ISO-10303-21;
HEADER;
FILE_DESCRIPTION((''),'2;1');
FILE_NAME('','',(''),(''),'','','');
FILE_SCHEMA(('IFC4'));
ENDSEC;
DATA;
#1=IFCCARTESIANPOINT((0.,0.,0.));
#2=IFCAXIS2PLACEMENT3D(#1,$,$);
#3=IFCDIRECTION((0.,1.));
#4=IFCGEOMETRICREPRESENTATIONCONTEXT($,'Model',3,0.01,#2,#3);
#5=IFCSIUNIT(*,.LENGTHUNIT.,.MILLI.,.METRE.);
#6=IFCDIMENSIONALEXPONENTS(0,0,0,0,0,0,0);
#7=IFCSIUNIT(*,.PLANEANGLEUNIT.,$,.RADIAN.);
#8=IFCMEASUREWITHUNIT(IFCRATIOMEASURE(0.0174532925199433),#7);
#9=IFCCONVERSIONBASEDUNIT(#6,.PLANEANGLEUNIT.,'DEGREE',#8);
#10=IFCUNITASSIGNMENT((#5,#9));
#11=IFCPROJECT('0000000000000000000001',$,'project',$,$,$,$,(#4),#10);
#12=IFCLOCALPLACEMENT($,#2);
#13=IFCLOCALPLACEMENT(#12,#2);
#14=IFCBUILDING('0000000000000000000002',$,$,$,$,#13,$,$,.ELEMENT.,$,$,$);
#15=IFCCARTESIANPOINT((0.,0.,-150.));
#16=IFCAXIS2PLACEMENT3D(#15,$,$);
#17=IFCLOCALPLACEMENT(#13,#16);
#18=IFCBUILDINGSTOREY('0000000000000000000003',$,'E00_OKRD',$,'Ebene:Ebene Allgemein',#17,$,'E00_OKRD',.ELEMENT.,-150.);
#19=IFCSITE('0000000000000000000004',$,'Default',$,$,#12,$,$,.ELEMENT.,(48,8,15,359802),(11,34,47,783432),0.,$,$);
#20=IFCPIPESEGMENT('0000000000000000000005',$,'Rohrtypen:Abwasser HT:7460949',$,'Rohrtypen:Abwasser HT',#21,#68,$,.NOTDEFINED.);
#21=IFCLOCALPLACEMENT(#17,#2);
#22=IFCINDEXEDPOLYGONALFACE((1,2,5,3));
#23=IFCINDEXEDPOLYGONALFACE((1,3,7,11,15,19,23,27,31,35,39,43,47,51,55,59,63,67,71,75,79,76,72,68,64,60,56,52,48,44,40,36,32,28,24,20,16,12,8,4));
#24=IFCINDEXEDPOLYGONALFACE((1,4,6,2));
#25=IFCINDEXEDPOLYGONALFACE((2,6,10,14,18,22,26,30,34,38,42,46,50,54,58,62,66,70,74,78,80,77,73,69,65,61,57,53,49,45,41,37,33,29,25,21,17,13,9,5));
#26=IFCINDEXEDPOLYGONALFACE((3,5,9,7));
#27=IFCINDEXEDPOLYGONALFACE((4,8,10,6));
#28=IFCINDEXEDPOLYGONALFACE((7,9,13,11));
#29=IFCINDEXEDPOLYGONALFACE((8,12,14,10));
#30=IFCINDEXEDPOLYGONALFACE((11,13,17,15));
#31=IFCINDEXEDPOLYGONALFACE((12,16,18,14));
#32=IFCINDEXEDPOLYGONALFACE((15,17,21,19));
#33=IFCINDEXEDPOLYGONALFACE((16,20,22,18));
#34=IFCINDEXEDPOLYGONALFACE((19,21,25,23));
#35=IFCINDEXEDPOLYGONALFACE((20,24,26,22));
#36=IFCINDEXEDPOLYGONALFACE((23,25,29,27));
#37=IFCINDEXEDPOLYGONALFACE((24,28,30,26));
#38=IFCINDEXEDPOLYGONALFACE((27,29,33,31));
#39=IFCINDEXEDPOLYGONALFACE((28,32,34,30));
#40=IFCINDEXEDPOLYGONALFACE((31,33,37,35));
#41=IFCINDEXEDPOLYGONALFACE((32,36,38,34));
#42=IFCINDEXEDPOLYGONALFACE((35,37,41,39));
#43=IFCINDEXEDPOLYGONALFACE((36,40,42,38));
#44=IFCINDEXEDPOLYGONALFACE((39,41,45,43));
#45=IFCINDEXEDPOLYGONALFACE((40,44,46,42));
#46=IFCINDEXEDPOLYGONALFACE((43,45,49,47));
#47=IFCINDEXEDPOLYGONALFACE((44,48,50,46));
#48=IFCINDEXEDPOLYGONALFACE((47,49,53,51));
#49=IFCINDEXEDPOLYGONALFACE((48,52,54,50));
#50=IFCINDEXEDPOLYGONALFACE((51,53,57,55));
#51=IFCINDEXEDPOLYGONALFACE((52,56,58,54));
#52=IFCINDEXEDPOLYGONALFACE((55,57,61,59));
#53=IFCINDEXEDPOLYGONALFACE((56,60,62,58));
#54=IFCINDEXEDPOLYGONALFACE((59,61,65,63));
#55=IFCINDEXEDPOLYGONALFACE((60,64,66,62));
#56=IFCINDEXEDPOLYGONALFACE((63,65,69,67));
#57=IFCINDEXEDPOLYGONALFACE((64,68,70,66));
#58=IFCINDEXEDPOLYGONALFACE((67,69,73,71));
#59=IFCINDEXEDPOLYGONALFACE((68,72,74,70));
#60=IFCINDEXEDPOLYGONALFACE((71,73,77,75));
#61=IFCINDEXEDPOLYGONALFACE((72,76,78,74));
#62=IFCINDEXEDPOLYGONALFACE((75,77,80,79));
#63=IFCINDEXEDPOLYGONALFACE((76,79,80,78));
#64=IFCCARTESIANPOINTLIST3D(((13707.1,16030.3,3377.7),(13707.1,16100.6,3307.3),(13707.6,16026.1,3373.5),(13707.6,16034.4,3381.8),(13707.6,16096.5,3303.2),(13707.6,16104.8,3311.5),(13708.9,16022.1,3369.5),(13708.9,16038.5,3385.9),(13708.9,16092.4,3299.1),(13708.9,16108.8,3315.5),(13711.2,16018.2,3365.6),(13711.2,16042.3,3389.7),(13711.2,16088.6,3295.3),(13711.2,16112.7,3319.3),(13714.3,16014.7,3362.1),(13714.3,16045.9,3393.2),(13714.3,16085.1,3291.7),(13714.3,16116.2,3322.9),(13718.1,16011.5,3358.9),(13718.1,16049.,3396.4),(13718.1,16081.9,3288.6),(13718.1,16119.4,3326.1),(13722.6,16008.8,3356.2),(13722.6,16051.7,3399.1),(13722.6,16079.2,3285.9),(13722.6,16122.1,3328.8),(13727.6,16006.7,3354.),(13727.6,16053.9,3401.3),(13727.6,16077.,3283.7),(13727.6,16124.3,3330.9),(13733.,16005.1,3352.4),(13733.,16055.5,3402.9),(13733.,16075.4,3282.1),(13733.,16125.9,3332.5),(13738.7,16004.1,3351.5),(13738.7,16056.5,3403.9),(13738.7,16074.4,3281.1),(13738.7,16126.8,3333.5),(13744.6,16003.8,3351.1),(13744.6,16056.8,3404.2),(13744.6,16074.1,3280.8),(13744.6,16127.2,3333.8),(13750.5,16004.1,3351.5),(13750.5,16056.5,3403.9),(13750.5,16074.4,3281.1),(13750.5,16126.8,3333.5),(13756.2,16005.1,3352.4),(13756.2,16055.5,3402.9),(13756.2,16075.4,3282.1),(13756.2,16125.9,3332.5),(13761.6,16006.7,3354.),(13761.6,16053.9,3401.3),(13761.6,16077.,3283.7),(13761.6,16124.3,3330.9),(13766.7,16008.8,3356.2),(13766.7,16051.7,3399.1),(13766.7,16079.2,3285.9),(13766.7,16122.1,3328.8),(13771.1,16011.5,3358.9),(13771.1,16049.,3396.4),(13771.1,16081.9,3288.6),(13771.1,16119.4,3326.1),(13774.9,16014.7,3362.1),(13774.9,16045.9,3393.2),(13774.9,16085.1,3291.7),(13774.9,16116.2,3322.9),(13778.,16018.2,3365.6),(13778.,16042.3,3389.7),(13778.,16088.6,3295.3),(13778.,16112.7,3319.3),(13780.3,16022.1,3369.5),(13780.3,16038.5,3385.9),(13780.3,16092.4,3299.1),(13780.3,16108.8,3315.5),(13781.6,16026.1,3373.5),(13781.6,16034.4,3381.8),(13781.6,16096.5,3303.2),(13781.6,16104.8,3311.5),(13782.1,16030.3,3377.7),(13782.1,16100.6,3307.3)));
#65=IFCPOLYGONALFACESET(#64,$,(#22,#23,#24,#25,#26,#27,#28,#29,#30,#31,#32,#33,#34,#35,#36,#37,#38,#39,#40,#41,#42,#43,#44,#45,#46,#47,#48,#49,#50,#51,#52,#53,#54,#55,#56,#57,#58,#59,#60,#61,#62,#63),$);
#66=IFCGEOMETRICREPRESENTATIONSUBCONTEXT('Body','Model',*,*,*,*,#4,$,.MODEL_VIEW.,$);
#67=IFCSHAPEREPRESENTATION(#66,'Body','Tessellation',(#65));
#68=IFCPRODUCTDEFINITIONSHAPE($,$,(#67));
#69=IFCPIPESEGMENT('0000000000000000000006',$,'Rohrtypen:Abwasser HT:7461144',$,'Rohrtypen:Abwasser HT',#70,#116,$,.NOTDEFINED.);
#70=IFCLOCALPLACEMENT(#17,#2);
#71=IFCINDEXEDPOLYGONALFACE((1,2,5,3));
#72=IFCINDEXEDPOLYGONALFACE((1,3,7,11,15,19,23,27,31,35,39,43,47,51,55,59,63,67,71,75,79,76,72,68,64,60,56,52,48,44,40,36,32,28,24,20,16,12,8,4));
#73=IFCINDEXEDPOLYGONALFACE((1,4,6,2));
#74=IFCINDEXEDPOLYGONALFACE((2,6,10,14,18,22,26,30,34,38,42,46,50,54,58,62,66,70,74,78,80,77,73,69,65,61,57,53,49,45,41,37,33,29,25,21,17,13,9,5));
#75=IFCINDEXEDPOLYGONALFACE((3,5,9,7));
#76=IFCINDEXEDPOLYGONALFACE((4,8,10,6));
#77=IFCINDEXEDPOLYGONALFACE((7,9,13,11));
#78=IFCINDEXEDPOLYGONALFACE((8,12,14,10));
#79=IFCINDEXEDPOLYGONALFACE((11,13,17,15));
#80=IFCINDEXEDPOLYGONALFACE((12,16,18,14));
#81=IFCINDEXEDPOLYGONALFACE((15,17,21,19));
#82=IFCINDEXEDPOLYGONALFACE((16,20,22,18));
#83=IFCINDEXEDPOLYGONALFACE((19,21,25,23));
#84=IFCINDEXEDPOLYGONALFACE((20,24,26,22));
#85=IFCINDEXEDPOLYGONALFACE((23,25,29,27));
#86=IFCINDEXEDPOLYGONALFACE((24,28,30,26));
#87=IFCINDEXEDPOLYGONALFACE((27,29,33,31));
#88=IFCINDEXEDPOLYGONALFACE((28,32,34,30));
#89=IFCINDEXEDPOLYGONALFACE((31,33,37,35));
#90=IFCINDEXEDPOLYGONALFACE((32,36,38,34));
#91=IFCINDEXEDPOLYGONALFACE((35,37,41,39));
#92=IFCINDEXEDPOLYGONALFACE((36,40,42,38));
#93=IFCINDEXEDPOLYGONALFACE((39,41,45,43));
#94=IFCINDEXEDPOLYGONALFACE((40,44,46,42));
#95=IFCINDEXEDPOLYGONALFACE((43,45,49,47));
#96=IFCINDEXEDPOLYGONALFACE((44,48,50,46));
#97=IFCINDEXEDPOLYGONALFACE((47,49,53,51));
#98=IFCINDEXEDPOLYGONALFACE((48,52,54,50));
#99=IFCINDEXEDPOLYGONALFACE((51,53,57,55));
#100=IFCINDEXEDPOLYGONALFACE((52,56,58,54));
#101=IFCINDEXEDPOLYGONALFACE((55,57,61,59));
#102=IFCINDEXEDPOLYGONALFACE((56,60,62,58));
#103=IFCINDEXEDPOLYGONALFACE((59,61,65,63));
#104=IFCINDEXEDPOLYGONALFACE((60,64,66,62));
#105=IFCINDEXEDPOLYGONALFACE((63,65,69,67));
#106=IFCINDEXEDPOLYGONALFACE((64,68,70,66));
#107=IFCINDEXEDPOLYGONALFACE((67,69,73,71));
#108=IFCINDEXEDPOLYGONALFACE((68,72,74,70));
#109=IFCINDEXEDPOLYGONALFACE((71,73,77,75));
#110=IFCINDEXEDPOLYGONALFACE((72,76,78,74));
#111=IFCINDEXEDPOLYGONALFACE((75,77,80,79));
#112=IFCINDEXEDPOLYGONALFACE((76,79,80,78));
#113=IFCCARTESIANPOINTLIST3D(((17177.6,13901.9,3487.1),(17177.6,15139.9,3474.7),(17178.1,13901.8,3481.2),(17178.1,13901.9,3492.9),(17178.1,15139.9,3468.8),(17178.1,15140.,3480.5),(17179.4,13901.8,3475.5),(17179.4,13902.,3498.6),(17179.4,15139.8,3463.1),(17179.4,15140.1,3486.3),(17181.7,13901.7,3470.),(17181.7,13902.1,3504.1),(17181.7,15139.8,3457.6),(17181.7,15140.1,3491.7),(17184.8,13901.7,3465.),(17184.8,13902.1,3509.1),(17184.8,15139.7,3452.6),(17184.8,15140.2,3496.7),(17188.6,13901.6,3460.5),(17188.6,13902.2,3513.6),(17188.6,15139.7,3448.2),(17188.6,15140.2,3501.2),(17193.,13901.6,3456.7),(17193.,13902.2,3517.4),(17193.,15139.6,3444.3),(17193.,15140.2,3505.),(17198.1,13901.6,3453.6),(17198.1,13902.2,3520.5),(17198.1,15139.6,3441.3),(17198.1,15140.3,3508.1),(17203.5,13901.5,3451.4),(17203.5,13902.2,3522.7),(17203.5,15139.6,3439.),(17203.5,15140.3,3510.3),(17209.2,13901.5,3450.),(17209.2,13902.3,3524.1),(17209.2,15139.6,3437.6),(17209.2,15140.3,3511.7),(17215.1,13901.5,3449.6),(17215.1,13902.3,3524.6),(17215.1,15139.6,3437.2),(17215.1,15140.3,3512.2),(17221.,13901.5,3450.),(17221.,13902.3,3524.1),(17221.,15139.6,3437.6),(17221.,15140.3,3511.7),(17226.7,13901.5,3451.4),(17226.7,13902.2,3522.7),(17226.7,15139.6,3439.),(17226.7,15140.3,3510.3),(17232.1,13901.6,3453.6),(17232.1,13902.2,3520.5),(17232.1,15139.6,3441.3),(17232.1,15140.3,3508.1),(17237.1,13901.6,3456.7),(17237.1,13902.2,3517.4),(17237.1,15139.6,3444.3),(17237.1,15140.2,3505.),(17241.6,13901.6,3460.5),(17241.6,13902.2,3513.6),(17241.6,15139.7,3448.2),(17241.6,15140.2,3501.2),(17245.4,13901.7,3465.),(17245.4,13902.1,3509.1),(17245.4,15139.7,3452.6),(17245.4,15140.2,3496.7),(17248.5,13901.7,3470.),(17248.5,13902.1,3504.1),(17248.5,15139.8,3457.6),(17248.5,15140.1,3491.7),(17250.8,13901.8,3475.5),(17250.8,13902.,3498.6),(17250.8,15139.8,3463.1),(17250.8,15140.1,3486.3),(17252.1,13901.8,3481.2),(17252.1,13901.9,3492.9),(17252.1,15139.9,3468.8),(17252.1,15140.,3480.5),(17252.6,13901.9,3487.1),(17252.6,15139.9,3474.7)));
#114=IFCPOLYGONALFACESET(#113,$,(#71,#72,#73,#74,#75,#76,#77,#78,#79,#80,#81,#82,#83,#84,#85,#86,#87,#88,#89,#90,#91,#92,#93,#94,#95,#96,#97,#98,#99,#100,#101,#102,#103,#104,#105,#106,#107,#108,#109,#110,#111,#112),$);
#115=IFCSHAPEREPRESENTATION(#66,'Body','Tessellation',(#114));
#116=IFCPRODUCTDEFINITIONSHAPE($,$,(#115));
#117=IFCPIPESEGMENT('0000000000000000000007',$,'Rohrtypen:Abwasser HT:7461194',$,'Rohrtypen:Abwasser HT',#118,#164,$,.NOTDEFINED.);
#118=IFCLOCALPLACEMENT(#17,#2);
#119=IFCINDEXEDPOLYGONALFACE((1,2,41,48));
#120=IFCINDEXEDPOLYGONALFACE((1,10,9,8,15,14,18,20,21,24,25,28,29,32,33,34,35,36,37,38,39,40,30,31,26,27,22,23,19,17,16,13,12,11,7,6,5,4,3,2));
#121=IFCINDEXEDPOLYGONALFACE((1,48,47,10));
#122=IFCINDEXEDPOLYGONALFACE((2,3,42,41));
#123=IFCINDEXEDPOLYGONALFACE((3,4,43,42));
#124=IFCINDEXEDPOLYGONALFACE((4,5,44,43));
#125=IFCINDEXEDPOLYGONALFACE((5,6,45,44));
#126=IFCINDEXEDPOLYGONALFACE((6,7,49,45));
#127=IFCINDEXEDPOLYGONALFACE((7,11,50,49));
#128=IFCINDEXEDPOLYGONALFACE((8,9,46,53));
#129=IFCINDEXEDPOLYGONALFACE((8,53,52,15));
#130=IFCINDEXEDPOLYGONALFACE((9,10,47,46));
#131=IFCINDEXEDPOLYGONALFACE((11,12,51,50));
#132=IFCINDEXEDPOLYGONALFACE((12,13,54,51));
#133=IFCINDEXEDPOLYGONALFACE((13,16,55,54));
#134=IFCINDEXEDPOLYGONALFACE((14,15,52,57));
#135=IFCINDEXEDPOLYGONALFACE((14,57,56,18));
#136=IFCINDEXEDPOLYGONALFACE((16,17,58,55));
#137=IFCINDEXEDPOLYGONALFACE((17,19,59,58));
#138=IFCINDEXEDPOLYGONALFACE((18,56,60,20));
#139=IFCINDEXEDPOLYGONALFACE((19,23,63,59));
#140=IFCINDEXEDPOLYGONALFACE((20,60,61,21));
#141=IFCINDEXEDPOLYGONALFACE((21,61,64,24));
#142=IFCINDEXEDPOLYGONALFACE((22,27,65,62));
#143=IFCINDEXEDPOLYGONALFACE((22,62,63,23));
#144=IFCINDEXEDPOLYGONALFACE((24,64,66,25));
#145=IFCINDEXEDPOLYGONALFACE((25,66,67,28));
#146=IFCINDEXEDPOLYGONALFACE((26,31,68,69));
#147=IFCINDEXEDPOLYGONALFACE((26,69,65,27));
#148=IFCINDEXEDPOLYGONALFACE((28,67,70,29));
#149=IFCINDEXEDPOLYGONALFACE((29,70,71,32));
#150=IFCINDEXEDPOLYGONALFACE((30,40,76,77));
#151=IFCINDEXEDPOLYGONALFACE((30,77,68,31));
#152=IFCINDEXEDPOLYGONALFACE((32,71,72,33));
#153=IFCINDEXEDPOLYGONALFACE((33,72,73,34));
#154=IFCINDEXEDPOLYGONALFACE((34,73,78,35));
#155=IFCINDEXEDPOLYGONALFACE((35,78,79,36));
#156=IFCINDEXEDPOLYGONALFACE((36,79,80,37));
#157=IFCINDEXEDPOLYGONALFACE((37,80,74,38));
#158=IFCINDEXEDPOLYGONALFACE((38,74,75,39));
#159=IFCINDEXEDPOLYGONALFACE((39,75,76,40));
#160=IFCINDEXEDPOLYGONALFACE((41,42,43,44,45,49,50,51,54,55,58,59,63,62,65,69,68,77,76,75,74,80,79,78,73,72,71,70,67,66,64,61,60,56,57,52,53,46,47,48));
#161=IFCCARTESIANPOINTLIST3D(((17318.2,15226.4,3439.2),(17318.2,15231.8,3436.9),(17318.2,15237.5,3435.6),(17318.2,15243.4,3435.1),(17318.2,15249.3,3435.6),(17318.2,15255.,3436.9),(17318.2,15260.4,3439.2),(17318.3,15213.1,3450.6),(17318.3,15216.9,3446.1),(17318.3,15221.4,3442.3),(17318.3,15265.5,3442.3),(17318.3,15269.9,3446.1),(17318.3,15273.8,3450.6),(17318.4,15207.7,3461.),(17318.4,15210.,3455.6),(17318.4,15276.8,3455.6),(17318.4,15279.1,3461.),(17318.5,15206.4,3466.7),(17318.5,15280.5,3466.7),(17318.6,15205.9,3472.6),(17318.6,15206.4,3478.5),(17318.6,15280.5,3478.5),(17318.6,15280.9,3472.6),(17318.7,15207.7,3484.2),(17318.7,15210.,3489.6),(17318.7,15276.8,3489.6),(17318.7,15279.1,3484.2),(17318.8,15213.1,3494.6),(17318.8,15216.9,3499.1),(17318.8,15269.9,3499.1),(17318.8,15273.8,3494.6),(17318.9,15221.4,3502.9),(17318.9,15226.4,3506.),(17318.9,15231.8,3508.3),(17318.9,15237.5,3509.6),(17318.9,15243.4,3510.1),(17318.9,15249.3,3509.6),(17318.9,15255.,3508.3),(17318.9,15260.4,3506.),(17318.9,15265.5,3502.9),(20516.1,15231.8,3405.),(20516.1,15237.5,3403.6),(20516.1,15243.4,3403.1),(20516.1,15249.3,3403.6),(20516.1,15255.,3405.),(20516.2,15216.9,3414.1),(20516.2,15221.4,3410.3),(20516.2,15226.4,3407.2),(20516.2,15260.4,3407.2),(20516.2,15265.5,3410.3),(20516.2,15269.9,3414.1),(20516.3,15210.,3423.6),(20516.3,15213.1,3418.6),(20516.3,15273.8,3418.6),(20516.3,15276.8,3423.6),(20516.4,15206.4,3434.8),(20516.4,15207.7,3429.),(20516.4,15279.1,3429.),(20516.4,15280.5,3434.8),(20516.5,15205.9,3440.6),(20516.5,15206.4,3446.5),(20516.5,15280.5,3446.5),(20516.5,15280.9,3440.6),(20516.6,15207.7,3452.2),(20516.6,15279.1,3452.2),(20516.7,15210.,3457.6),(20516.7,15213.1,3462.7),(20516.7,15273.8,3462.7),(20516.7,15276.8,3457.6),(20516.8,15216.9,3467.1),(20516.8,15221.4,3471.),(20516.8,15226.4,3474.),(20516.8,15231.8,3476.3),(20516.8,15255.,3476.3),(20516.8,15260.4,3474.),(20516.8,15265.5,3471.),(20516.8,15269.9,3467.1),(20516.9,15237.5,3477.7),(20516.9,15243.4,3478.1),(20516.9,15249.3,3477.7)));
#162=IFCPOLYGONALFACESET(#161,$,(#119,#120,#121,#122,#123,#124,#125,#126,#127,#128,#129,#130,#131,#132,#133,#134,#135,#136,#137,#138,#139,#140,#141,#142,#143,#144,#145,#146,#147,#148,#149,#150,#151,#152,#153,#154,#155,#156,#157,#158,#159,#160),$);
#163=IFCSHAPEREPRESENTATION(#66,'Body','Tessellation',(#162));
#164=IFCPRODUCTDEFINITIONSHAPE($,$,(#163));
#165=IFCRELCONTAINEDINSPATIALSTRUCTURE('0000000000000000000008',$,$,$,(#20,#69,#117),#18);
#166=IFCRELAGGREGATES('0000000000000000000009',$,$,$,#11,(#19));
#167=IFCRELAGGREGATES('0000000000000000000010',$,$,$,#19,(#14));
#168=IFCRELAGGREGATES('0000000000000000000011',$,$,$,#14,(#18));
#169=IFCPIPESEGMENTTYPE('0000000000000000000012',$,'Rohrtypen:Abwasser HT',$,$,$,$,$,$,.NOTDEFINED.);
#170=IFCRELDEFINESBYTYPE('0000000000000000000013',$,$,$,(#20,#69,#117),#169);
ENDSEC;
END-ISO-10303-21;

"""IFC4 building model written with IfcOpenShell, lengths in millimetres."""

from ifc_helpers import new_model, entity, si_unit, converted_unit, direction, frame, origin, place, context, subcontext, project, spatial, indexed_curve, outline, extrude, type_object, element, save


model = new_model("IFC4")

# Units and contexts
model_context = context("Model", 3, precision=0.01, world=origin(), true_north=direction((0.0, 1.0)))
body_context = subcontext(model_context, "Body", "Model", "MODEL_VIEW")
ifc_project = project(units=[si_unit("LENGTHUNIT", "METRE", prefix="MILLI"), converted_unit("PLANEANGLEUNIT", "DEGREE", entity("IfcRatioMeasure", 0.0174532925199433), si_unit("PLANEANGLEUNIT", "RADIAN"), dimensions=[0, 0, 0, 0, 0, 0, 0])], contexts=[model_context])

# Site, building, storey
site_placement = place(None, origin())
site = spatial("IfcSite", under=ifc_project, at=site_placement, Name="Default", CompositionType="ELEMENT", RefLatitude=(48, 8, 15, 359802), RefLongitude=(11, 34, 47, 783432), RefElevation=0.0)
building_placement = place(site_placement, origin())
building = spatial("IfcBuilding", under=site, at=building_placement, CompositionType="ELEMENT")
storey_placement = place(building_placement, frame((0.0, 0.0, -150.0)))
storey = spatial("IfcBuildingStorey", under=building, at=storey_placement, Name="E00_OKRD", ObjectType="Ebene:Ebene Allgemein", LongName="E00_OKRD", CompositionType="ELEMENT", Elevation=-150.0)

# Pipe segments
pipe_segment_type_1 = type_object("IfcPipeSegmentType", Name="Rohrtypen:Abwasser HT", PredefinedType="NOTDEFINED")
pipe_segment_1_placement = place(storey_placement, origin())
element("IfcPipeSegment", 1, at=pipe_segment_1_placement, inside=storey, type_object=pipe_segment_type_1, Name="Rohrtypen:Abwasser HT:7460949", ObjectType="Rohrtypen:Abwasser HT", PredefinedType="NOTDEFINED", context=body_context, shape_type="SweptSolid", body=[
    extrude(outline(indexed_curve([(37.5, 0.0), (37.0, 5.9), (35.7, 11.6), (33.4, 17.0), (30.3, 22.0), (26.5, 26.5), (22.0, 30.3), (17.0, 33.4), (11.6, 35.7), (5.9, 37.0), (0.0, 37.5), (-5.9, 37.0), (-11.6, 35.7), (-17.0, 33.4), (-22.0, 30.3), (-26.5, 26.5), (-30.3, 22.0), (-33.4, 17.0), (-35.7, 11.6), (-37.0, 5.9), (-37.5, 0.0), (-37.0, -5.9), (-35.7, -11.6), (-33.4, -17.0), (-30.3, -22.0), (-26.5, -26.5), (-22.0, -30.3), (-17.0, -33.4), (-11.6, -35.7), (-5.9, -37.0), (0.0, -37.5), (5.9, -37.0), (11.6, -35.7), (17.0, -33.4), (22.0, -30.3), (26.5, -26.5), (30.3, -22.0), (33.4, -17.0), (35.7, -11.6), (37.0, -5.9), (37.5, 0.0)], self_intersect=False)), frame((13744.6, 16030.3, 3377.7), z_axis=(0.0, 0.707107, -0.707107), x_axis=(1.0, 0.0, 0.0)), (0.0, 0.0, 1.0), 99.5),
])
pipe_segment_2_placement = place(storey_placement, origin())
element("IfcPipeSegment", 2, at=pipe_segment_2_placement, inside=storey, type_object=pipe_segment_type_1, Name="Rohrtypen:Abwasser HT:7461144", ObjectType="Rohrtypen:Abwasser HT", PredefinedType="NOTDEFINED", context=body_context, shape_type="SweptSolid", body=[
    extrude(outline(indexed_curve([(37.5, 0.0), (37.0, 5.9), (35.7, 11.6), (33.4, 17.0), (30.3, 22.0), (26.5, 26.5), (22.0, 30.3), (17.0, 33.4), (11.6, 35.7), (5.9, 37.0), (0.0, 37.5), (-5.9, 37.0), (-11.6, 35.7), (-17.0, 33.4), (-22.0, 30.3), (-26.5, 26.5), (-30.3, 22.0), (-33.4, 17.0), (-35.7, 11.6), (-37.0, 5.9), (-37.5, 0.0), (-37.0, -5.9), (-35.7, -11.6), (-33.4, -17.0), (-30.3, -22.0), (-26.5, -26.5), (-22.0, -30.3), (-17.0, -33.4), (-11.6, -35.7), (-5.9, -37.0), (0.0, -37.5), (5.9, -37.0), (11.6, -35.7), (17.0, -33.4), (22.0, -30.3), (26.5, -26.5), (30.3, -22.0), (33.4, -17.0), (35.7, -11.6), (37.0, -5.9), (37.5, 0.0)], self_intersect=False)), frame((17215.1, 13901.9, 3487.1), z_axis=(0.0, 0.99995, -0.01), x_axis=(1.0, 0.0, 0.0)), (0.0, 0.0, 1.0), 1238.1),
])
pipe_segment_3_placement = place(storey_placement, origin())
element("IfcPipeSegment", 3, at=pipe_segment_3_placement, inside=storey, type_object=pipe_segment_type_1, Name="Rohrtypen:Abwasser HT:7461194", ObjectType="Rohrtypen:Abwasser HT", PredefinedType="NOTDEFINED", context=body_context, shape_type="SweptSolid", body=[
    extrude(outline(indexed_curve([(37.5, 0.0), (37.0, 5.9), (35.7, 11.6), (33.4, 17.0), (30.3, 22.0), (26.5, 26.5), (22.0, 30.3), (17.0, 33.4), (11.6, 35.7), (5.9, 37.0), (0.0, 37.5), (-5.9, 37.0), (-11.6, 35.7), (-17.0, 33.4), (-22.0, 30.3), (-26.5, 26.5), (-30.3, 22.0), (-33.4, 17.0), (-35.7, 11.6), (-37.0, 5.9), (-37.5, 0.0), (-37.0, -5.9), (-35.7, -11.6), (-33.4, -17.0), (-30.3, -22.0), (-26.5, -26.5), (-22.0, -30.3), (-17.0, -33.4), (-11.6, -35.7), (-5.9, -37.0), (0.0, -37.5), (5.9, -37.0), (11.6, -35.7), (17.0, -33.4), (22.0, -30.3), (26.5, -26.5), (30.3, -22.0), (33.4, -17.0), (35.7, -11.6), (37.0, -5.9), (37.5, 0.0)], self_intersect=False)), frame((20516.5, 15243.4, 3440.6), z_axis=(-0.99995, 0.0, 0.01), x_axis=(0.0, -1.0, 0.0)), (0.0, 0.0, 1.0), 3198.1),
])

save(model, "model.ifc")
